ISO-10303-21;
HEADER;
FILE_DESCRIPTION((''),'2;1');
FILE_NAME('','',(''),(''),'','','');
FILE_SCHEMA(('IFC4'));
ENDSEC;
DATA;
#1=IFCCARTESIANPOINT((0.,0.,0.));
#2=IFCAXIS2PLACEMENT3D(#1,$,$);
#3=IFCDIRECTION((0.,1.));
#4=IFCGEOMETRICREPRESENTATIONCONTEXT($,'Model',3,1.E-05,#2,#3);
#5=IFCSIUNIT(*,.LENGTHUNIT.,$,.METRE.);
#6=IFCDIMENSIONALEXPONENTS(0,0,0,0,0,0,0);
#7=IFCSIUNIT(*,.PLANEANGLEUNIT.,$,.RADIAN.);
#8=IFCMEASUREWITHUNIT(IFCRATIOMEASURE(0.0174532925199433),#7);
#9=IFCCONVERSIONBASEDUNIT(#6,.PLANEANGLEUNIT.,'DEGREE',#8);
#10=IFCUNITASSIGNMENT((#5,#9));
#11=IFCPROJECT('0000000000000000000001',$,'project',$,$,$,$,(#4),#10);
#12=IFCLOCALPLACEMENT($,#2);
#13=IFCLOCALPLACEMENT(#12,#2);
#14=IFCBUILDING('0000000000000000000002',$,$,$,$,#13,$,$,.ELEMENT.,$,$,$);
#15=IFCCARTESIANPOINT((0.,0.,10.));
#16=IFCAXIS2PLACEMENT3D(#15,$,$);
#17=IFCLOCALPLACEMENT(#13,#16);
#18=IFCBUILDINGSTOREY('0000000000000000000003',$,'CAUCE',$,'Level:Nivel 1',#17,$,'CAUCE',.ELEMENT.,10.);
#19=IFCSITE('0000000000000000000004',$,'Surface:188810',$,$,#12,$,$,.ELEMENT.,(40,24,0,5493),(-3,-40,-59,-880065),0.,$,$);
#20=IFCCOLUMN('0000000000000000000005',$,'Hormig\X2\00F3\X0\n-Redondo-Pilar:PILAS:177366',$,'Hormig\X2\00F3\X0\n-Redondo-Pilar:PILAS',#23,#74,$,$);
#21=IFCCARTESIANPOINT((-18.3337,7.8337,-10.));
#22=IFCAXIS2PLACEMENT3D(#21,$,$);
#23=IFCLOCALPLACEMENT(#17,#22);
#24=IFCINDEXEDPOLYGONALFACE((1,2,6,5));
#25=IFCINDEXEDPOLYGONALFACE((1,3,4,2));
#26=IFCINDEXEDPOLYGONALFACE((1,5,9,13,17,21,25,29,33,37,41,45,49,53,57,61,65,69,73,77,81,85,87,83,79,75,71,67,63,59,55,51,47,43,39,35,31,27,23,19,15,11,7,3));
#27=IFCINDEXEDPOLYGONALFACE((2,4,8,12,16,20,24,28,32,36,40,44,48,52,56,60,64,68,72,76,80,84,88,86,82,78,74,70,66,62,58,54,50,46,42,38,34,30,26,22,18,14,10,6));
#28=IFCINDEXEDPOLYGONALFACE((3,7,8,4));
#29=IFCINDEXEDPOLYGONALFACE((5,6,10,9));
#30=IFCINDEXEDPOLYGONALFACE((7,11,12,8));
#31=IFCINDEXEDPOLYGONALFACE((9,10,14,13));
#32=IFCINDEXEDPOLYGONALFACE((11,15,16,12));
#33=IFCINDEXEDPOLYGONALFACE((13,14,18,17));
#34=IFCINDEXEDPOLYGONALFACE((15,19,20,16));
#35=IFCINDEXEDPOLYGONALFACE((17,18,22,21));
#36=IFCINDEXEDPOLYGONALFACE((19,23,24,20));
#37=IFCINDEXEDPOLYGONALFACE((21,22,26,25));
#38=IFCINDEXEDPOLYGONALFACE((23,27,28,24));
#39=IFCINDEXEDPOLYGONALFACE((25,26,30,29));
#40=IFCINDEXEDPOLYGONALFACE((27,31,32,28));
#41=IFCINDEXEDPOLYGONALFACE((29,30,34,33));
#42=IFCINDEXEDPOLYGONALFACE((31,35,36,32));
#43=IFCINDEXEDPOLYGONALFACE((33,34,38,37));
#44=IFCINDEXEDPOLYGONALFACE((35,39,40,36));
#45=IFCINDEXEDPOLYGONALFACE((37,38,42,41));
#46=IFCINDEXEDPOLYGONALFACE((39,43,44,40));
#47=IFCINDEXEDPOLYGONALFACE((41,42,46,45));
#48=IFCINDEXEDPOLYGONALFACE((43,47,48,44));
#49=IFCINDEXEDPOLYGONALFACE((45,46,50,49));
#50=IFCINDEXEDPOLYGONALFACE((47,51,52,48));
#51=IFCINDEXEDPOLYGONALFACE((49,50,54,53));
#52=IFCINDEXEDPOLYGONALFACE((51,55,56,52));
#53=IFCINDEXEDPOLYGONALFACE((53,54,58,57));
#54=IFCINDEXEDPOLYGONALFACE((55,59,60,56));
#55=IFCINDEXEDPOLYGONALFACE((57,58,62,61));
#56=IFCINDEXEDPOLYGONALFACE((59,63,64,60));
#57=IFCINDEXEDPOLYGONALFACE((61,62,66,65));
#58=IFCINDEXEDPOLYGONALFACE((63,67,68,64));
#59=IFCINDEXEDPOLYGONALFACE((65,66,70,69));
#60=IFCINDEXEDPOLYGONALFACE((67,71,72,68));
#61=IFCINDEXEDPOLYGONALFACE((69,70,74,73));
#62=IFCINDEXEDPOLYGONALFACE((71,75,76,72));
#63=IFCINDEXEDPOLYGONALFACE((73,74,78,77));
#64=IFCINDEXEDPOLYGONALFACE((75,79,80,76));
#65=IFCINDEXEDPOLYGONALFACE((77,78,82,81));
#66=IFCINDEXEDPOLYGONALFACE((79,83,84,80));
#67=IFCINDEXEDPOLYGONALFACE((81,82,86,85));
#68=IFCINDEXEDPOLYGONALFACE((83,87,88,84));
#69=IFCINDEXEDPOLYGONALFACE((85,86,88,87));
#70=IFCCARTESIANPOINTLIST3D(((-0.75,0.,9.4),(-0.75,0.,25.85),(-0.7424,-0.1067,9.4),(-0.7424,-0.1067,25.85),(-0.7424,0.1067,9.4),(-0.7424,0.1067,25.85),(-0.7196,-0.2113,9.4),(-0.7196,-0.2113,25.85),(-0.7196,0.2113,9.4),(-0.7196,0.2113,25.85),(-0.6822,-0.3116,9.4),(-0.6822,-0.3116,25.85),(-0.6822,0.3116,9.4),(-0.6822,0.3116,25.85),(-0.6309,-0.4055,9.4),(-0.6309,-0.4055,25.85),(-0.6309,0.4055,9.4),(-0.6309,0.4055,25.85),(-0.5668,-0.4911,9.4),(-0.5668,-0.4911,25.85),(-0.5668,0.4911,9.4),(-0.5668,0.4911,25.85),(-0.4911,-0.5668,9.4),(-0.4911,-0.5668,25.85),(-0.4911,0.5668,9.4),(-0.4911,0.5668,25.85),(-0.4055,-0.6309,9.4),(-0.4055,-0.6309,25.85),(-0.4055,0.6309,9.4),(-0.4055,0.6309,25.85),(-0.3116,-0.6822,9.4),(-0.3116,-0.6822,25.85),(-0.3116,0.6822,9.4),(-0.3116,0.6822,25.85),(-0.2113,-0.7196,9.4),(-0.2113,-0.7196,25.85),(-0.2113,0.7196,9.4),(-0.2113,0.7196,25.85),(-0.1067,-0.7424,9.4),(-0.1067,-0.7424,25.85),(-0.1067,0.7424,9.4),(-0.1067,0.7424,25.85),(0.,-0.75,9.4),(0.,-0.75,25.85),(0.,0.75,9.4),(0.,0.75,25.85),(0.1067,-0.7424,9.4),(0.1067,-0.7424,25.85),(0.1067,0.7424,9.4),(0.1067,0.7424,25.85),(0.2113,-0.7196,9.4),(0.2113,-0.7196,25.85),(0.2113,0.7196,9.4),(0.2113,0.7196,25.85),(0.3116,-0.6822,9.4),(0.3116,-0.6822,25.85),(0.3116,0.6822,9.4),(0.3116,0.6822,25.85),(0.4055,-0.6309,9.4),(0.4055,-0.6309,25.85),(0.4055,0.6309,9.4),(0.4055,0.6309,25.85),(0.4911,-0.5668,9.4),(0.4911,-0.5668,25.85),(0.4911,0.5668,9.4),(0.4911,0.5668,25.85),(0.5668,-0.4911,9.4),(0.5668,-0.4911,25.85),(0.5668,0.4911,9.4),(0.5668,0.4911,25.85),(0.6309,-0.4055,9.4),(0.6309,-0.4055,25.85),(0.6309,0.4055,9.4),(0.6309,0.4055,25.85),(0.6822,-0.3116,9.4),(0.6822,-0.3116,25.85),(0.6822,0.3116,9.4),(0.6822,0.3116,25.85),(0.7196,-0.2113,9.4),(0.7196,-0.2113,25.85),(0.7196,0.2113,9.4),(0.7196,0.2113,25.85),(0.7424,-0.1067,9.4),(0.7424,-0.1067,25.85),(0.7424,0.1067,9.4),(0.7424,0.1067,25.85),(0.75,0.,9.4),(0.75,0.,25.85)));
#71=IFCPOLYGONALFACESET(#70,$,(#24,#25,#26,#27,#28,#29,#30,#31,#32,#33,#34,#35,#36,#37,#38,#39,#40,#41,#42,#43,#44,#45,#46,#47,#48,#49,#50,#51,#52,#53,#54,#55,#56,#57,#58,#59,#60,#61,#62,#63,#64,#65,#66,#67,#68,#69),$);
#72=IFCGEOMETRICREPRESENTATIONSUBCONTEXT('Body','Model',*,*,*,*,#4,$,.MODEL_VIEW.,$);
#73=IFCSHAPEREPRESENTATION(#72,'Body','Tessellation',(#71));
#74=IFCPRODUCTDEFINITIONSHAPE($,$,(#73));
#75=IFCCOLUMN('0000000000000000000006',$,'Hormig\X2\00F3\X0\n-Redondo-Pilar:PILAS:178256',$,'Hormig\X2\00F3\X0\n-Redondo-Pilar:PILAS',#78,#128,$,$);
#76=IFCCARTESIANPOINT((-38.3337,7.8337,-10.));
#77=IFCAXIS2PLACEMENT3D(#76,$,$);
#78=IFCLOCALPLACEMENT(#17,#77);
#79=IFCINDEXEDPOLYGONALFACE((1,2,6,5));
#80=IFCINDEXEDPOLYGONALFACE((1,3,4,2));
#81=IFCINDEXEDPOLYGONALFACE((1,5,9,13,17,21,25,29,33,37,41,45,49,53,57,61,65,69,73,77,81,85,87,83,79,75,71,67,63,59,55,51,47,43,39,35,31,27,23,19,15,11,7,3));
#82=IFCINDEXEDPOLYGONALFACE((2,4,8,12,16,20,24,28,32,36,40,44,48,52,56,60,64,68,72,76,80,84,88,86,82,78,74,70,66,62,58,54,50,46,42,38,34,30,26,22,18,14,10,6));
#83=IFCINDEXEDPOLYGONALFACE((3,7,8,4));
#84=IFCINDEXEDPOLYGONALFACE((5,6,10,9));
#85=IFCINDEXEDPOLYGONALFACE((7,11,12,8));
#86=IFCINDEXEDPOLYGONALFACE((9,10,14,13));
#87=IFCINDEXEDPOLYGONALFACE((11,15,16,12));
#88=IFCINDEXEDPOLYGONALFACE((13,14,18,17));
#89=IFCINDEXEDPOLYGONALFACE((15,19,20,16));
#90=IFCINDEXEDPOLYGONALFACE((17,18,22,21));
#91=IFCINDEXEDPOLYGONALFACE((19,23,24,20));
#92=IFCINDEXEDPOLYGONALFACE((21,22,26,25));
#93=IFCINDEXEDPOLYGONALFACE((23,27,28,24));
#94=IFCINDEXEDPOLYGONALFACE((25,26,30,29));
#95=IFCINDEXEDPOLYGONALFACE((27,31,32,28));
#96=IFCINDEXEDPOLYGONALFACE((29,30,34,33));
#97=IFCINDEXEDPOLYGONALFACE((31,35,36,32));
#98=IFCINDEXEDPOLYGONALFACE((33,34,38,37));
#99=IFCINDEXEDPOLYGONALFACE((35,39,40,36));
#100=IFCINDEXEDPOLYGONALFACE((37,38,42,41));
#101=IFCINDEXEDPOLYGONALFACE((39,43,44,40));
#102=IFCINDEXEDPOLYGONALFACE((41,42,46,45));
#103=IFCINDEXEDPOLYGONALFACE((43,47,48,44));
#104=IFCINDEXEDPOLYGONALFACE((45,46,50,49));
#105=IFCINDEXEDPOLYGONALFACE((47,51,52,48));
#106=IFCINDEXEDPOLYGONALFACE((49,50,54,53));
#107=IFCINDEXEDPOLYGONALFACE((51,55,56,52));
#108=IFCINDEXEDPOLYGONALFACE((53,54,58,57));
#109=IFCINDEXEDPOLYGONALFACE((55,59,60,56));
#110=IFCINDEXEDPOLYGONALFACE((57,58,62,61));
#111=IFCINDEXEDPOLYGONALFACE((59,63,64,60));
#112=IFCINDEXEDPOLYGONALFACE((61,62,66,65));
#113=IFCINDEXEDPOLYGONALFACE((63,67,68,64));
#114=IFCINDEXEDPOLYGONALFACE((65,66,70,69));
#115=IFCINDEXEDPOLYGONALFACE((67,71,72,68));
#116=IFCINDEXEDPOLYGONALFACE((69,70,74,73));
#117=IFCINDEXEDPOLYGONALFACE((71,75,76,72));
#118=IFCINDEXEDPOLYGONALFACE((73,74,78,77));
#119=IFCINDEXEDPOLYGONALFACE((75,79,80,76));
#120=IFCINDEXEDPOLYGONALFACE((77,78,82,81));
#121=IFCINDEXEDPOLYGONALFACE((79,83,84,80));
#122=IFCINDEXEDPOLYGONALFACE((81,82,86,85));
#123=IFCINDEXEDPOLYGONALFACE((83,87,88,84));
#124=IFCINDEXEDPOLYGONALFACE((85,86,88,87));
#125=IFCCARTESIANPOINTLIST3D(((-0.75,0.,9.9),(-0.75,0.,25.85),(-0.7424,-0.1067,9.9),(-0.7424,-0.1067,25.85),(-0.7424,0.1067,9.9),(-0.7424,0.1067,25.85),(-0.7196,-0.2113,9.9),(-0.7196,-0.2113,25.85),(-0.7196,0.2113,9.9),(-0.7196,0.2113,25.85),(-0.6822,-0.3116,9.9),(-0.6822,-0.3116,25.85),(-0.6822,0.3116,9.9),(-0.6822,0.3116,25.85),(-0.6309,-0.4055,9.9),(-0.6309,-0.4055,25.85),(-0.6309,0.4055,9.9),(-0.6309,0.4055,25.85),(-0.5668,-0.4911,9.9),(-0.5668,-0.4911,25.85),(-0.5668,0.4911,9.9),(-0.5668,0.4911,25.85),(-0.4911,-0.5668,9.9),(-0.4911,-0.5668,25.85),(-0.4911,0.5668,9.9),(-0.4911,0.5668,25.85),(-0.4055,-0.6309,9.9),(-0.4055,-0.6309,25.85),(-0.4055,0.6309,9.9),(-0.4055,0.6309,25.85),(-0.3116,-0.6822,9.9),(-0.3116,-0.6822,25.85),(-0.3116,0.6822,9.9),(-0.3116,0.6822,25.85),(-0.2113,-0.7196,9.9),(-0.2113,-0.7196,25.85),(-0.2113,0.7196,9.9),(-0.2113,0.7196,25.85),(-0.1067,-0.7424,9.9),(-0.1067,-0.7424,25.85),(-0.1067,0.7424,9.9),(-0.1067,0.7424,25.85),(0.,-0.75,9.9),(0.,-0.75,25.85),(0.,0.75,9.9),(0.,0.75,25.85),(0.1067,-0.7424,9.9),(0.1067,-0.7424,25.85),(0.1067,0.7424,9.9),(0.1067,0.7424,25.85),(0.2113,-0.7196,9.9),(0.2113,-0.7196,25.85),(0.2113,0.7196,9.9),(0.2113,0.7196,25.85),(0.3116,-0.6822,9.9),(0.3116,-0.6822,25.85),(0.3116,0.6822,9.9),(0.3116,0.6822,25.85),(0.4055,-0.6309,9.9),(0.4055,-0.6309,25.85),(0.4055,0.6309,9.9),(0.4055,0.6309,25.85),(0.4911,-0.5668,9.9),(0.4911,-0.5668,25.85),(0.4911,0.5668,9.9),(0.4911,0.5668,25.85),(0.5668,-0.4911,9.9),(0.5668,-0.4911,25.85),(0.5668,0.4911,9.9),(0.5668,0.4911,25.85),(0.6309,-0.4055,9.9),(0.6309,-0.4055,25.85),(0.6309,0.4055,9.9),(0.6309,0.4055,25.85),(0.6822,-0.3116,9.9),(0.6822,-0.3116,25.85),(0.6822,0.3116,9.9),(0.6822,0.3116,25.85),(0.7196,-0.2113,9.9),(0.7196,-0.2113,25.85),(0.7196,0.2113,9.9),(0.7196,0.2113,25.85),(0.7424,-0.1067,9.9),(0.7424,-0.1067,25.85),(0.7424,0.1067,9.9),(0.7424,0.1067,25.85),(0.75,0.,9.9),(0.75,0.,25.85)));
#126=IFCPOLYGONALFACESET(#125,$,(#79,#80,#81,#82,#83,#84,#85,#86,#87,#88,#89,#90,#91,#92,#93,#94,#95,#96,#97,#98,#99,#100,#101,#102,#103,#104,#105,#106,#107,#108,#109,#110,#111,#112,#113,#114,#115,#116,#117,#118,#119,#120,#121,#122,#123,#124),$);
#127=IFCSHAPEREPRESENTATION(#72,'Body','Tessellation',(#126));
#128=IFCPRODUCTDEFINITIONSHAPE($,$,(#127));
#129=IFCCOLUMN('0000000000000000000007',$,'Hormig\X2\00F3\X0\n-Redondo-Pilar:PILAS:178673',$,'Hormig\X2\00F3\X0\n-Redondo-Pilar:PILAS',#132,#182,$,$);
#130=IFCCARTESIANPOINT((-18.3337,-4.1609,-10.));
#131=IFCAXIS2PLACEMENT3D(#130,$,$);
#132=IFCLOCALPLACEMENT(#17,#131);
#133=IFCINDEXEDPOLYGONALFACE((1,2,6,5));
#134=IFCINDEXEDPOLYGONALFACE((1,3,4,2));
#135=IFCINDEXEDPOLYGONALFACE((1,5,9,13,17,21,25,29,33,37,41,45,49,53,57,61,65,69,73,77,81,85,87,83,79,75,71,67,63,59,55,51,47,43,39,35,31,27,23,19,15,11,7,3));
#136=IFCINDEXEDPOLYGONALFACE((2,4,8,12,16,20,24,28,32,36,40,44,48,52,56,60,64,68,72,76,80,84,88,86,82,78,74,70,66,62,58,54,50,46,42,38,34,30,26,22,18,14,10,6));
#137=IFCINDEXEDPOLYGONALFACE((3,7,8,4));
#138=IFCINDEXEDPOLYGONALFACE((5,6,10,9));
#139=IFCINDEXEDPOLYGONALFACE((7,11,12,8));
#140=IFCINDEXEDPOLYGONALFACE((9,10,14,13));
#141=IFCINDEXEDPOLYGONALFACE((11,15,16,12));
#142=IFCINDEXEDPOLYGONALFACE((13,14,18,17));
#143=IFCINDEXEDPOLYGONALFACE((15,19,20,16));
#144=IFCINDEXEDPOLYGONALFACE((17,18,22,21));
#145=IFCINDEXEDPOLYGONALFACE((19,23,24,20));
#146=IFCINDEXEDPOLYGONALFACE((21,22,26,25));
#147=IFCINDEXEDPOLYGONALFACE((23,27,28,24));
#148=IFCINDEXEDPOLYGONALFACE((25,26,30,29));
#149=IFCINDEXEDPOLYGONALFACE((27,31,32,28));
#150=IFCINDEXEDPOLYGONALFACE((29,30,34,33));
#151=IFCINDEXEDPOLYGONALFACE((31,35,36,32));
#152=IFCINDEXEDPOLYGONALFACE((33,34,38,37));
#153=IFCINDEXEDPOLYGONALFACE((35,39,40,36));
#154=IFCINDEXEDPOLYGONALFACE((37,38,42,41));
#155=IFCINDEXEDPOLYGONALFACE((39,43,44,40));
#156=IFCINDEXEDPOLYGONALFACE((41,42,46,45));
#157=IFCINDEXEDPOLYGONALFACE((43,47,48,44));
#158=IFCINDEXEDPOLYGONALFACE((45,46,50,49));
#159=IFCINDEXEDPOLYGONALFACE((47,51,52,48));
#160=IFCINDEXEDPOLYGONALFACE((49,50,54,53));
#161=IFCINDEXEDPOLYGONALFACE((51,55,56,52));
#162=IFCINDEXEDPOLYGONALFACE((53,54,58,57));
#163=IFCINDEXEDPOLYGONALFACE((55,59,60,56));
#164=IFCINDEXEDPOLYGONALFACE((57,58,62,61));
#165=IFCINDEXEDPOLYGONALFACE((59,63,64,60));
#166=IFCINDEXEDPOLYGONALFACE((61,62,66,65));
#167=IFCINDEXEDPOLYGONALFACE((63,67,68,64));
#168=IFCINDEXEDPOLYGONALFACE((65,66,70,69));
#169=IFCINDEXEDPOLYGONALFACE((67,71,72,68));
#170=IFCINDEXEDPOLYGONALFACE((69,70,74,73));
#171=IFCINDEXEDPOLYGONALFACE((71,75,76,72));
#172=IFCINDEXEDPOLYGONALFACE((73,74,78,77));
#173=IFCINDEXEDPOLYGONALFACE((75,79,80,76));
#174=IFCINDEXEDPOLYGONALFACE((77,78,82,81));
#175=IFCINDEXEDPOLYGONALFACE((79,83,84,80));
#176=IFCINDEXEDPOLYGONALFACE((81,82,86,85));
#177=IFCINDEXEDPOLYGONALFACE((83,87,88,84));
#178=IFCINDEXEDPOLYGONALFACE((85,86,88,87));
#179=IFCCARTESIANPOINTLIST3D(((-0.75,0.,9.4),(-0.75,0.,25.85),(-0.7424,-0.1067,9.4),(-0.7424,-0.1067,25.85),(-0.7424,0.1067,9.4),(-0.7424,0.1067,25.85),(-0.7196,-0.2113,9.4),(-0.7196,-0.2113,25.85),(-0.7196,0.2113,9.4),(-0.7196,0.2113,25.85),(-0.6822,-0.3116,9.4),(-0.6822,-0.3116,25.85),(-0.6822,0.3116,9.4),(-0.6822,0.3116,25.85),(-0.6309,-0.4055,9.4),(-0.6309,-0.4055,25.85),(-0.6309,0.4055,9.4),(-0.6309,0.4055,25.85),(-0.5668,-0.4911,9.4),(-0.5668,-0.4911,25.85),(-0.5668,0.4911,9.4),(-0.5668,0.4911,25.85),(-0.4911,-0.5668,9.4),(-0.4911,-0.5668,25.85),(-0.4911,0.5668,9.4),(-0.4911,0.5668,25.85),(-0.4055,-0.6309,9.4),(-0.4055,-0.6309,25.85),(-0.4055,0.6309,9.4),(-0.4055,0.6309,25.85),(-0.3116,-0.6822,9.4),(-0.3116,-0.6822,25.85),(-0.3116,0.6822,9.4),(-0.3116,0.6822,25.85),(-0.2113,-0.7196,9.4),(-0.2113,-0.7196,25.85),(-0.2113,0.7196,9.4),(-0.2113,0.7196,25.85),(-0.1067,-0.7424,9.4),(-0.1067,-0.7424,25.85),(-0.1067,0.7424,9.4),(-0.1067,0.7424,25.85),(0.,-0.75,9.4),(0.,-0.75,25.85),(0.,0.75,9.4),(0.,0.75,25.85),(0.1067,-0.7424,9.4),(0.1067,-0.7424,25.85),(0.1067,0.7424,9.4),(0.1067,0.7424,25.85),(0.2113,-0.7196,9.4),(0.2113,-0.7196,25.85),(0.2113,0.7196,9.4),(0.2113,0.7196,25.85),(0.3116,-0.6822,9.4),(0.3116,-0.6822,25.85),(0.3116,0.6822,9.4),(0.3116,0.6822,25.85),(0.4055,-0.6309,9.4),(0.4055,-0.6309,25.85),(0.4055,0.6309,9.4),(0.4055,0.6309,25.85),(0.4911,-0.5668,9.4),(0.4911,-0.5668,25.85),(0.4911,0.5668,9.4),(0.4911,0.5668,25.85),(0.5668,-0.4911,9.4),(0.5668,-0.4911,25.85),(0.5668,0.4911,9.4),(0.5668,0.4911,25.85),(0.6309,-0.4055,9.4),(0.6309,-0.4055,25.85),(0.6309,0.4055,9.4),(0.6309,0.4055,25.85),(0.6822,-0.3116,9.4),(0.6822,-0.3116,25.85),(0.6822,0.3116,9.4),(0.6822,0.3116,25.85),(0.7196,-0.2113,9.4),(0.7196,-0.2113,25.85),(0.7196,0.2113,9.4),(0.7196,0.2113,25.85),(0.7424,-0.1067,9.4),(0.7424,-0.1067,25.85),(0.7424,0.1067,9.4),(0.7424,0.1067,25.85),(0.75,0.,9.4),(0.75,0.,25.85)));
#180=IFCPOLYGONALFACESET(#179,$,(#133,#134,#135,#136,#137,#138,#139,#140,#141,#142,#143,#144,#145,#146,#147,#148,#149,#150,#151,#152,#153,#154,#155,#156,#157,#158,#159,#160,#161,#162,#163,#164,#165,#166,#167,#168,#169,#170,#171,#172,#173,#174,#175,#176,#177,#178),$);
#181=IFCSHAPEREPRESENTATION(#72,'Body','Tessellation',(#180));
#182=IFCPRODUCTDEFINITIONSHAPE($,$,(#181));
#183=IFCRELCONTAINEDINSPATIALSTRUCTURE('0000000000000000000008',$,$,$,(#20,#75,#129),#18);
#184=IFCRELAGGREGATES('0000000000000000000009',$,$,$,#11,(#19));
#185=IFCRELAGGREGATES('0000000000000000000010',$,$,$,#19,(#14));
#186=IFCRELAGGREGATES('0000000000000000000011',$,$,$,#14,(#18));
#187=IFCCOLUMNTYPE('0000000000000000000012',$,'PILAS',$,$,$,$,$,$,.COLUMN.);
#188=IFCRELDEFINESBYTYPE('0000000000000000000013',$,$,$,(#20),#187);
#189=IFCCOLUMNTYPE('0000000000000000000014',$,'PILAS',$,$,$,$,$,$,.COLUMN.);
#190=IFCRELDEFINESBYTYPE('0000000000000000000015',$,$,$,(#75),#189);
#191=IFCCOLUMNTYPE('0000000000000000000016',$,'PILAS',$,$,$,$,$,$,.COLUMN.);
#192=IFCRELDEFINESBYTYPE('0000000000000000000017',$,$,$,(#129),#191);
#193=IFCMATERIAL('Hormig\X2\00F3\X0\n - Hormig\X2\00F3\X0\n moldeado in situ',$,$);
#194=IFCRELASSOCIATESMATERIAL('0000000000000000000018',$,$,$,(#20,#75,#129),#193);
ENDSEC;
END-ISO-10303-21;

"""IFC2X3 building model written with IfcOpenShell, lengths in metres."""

from ifc_helpers import new_model, entity, si_unit, converted_unit, direction, frame, frame_2d, origin, place, context, subcontext, project, spatial, circle, extrude, source, transform, mapped, material, type_object, type_shapes, element, save


model = new_model("IFC2X3")

# Units and contexts
model_context = context("Model", 3, precision=1e-05, world=origin(), true_north=direction((0.0, 1.0)))
body_context = subcontext(model_context, "Body", "Model", "MODEL_VIEW")
ifc_project = project(units=[si_unit("LENGTHUNIT", "METRE"), converted_unit("PLANEANGLEUNIT", "DEGREE", entity("IfcRatioMeasure", 0.0174532925199433), si_unit("PLANEANGLEUNIT", "RADIAN"), dimensions=[0, 0, 0, 0, 0, 0, 0])], contexts=[model_context])

# Site, building, storey
site_placement = place(None, origin())
site = spatial("IfcSite", under=ifc_project, at=site_placement, Name="Surface:188810", CompositionType="ELEMENT", RefLatitude=(40, 24, 0, 5493), RefLongitude=(-3, -40, -59, -880065), RefElevation=0.0)
building_placement = place(site_placement, origin())
building = spatial("IfcBuilding", under=site, at=building_placement, CompositionType="ELEMENT")
storey_placement = place(building_placement, frame((0.0, 0.0, 10.0)))
storey = spatial("IfcBuildingStorey", under=building, at=storey_placement, Name="CAUCE", ObjectType="Level:Nivel 1", LongName="CAUCE", CompositionType="ELEMENT", Elevation=10.0)

# Columns
ifc_material_1 = material(Name="Hormigón - Hormigón moldeado in situ")
column_type_1 = type_object("IfcColumnType", Name="PILAS", PredefinedType="COLUMN")
shared_shape_1 = source(origin(), body_context, "Body", "SweptSolid", [
    extrude(circle(Radius=0.75, at=frame_2d((0.0, 0.0), x_axis=(1.0, 0.0))), frame((0.0, 0.0, 9.4)), (0.0, 0.0, 1.0), 16.45),
])
type_shapes(column_type_1, [shared_shape_1])
column_1_placement = place(storey_placement, frame((-18.3337, 7.8337, -10.0)))
element("IfcColumn", 1, at=column_1_placement, inside=storey, type_object=column_type_1, material=ifc_material_1, Name="Hormigón-Redondo-Pilar:PILAS:177366", ObjectType="Hormigón-Redondo-Pilar:PILAS", context=body_context, shape_type="MappedRepresentation", body=[
    mapped(shared_shape_1, transform((0.0, 0.0, 0.0), scale=1.0)),
])
column_type_2 = type_object("IfcColumnType", Name="PILAS", PredefinedType="COLUMN")
shared_shape_2 = source(origin(), body_context, "Body", "SweptSolid", [
    extrude(circle(Radius=0.75, at=frame_2d((0.0, 0.0), x_axis=(1.0, 0.0))), frame((0.0, 0.0, 9.9)), (0.0, 0.0, 1.0), 15.95),
])
type_shapes(column_type_2, [shared_shape_2])
column_2_placement = place(storey_placement, frame((-38.3337, 7.8337, -10.0)))
element("IfcColumn", 2, at=column_2_placement, inside=storey, type_object=column_type_2, material=ifc_material_1, Name="Hormigón-Redondo-Pilar:PILAS:178256", ObjectType="Hormigón-Redondo-Pilar:PILAS", context=body_context, shape_type="MappedRepresentation", body=[
    mapped(shared_shape_2, transform((0.0, 0.0, 0.0), scale=1.0)),
])
column_type_3 = type_object("IfcColumnType", Name="PILAS", PredefinedType="COLUMN")
shared_shape_3 = source(origin(), body_context, "Body", "SweptSolid", [
    extrude(circle(Radius=0.75, at=frame_2d((0.0, 0.0), x_axis=(1.0, 0.0))), frame((0.0, 0.0, 9.4), z_axis=(0.0, 0.0, 1.0), x_axis=(-1.0, 0.0, 0.0)), (0.0, 0.0, 1.0), 16.45),
])
type_shapes(column_type_3, [shared_shape_3])
column_3_placement = place(storey_placement, frame((-18.3337, -4.1609, -10.0)))
element("IfcColumn", 3, at=column_3_placement, inside=storey, type_object=column_type_3, material=ifc_material_1, Name="Hormigón-Redondo-Pilar:PILAS:178673", ObjectType="Hormigón-Redondo-Pilar:PILAS", context=body_context, shape_type="MappedRepresentation", body=[
    mapped(shared_shape_3, transform((0.0, 0.0, 0.0), scale=1.0)),
])

save(model, "model.ifc")
